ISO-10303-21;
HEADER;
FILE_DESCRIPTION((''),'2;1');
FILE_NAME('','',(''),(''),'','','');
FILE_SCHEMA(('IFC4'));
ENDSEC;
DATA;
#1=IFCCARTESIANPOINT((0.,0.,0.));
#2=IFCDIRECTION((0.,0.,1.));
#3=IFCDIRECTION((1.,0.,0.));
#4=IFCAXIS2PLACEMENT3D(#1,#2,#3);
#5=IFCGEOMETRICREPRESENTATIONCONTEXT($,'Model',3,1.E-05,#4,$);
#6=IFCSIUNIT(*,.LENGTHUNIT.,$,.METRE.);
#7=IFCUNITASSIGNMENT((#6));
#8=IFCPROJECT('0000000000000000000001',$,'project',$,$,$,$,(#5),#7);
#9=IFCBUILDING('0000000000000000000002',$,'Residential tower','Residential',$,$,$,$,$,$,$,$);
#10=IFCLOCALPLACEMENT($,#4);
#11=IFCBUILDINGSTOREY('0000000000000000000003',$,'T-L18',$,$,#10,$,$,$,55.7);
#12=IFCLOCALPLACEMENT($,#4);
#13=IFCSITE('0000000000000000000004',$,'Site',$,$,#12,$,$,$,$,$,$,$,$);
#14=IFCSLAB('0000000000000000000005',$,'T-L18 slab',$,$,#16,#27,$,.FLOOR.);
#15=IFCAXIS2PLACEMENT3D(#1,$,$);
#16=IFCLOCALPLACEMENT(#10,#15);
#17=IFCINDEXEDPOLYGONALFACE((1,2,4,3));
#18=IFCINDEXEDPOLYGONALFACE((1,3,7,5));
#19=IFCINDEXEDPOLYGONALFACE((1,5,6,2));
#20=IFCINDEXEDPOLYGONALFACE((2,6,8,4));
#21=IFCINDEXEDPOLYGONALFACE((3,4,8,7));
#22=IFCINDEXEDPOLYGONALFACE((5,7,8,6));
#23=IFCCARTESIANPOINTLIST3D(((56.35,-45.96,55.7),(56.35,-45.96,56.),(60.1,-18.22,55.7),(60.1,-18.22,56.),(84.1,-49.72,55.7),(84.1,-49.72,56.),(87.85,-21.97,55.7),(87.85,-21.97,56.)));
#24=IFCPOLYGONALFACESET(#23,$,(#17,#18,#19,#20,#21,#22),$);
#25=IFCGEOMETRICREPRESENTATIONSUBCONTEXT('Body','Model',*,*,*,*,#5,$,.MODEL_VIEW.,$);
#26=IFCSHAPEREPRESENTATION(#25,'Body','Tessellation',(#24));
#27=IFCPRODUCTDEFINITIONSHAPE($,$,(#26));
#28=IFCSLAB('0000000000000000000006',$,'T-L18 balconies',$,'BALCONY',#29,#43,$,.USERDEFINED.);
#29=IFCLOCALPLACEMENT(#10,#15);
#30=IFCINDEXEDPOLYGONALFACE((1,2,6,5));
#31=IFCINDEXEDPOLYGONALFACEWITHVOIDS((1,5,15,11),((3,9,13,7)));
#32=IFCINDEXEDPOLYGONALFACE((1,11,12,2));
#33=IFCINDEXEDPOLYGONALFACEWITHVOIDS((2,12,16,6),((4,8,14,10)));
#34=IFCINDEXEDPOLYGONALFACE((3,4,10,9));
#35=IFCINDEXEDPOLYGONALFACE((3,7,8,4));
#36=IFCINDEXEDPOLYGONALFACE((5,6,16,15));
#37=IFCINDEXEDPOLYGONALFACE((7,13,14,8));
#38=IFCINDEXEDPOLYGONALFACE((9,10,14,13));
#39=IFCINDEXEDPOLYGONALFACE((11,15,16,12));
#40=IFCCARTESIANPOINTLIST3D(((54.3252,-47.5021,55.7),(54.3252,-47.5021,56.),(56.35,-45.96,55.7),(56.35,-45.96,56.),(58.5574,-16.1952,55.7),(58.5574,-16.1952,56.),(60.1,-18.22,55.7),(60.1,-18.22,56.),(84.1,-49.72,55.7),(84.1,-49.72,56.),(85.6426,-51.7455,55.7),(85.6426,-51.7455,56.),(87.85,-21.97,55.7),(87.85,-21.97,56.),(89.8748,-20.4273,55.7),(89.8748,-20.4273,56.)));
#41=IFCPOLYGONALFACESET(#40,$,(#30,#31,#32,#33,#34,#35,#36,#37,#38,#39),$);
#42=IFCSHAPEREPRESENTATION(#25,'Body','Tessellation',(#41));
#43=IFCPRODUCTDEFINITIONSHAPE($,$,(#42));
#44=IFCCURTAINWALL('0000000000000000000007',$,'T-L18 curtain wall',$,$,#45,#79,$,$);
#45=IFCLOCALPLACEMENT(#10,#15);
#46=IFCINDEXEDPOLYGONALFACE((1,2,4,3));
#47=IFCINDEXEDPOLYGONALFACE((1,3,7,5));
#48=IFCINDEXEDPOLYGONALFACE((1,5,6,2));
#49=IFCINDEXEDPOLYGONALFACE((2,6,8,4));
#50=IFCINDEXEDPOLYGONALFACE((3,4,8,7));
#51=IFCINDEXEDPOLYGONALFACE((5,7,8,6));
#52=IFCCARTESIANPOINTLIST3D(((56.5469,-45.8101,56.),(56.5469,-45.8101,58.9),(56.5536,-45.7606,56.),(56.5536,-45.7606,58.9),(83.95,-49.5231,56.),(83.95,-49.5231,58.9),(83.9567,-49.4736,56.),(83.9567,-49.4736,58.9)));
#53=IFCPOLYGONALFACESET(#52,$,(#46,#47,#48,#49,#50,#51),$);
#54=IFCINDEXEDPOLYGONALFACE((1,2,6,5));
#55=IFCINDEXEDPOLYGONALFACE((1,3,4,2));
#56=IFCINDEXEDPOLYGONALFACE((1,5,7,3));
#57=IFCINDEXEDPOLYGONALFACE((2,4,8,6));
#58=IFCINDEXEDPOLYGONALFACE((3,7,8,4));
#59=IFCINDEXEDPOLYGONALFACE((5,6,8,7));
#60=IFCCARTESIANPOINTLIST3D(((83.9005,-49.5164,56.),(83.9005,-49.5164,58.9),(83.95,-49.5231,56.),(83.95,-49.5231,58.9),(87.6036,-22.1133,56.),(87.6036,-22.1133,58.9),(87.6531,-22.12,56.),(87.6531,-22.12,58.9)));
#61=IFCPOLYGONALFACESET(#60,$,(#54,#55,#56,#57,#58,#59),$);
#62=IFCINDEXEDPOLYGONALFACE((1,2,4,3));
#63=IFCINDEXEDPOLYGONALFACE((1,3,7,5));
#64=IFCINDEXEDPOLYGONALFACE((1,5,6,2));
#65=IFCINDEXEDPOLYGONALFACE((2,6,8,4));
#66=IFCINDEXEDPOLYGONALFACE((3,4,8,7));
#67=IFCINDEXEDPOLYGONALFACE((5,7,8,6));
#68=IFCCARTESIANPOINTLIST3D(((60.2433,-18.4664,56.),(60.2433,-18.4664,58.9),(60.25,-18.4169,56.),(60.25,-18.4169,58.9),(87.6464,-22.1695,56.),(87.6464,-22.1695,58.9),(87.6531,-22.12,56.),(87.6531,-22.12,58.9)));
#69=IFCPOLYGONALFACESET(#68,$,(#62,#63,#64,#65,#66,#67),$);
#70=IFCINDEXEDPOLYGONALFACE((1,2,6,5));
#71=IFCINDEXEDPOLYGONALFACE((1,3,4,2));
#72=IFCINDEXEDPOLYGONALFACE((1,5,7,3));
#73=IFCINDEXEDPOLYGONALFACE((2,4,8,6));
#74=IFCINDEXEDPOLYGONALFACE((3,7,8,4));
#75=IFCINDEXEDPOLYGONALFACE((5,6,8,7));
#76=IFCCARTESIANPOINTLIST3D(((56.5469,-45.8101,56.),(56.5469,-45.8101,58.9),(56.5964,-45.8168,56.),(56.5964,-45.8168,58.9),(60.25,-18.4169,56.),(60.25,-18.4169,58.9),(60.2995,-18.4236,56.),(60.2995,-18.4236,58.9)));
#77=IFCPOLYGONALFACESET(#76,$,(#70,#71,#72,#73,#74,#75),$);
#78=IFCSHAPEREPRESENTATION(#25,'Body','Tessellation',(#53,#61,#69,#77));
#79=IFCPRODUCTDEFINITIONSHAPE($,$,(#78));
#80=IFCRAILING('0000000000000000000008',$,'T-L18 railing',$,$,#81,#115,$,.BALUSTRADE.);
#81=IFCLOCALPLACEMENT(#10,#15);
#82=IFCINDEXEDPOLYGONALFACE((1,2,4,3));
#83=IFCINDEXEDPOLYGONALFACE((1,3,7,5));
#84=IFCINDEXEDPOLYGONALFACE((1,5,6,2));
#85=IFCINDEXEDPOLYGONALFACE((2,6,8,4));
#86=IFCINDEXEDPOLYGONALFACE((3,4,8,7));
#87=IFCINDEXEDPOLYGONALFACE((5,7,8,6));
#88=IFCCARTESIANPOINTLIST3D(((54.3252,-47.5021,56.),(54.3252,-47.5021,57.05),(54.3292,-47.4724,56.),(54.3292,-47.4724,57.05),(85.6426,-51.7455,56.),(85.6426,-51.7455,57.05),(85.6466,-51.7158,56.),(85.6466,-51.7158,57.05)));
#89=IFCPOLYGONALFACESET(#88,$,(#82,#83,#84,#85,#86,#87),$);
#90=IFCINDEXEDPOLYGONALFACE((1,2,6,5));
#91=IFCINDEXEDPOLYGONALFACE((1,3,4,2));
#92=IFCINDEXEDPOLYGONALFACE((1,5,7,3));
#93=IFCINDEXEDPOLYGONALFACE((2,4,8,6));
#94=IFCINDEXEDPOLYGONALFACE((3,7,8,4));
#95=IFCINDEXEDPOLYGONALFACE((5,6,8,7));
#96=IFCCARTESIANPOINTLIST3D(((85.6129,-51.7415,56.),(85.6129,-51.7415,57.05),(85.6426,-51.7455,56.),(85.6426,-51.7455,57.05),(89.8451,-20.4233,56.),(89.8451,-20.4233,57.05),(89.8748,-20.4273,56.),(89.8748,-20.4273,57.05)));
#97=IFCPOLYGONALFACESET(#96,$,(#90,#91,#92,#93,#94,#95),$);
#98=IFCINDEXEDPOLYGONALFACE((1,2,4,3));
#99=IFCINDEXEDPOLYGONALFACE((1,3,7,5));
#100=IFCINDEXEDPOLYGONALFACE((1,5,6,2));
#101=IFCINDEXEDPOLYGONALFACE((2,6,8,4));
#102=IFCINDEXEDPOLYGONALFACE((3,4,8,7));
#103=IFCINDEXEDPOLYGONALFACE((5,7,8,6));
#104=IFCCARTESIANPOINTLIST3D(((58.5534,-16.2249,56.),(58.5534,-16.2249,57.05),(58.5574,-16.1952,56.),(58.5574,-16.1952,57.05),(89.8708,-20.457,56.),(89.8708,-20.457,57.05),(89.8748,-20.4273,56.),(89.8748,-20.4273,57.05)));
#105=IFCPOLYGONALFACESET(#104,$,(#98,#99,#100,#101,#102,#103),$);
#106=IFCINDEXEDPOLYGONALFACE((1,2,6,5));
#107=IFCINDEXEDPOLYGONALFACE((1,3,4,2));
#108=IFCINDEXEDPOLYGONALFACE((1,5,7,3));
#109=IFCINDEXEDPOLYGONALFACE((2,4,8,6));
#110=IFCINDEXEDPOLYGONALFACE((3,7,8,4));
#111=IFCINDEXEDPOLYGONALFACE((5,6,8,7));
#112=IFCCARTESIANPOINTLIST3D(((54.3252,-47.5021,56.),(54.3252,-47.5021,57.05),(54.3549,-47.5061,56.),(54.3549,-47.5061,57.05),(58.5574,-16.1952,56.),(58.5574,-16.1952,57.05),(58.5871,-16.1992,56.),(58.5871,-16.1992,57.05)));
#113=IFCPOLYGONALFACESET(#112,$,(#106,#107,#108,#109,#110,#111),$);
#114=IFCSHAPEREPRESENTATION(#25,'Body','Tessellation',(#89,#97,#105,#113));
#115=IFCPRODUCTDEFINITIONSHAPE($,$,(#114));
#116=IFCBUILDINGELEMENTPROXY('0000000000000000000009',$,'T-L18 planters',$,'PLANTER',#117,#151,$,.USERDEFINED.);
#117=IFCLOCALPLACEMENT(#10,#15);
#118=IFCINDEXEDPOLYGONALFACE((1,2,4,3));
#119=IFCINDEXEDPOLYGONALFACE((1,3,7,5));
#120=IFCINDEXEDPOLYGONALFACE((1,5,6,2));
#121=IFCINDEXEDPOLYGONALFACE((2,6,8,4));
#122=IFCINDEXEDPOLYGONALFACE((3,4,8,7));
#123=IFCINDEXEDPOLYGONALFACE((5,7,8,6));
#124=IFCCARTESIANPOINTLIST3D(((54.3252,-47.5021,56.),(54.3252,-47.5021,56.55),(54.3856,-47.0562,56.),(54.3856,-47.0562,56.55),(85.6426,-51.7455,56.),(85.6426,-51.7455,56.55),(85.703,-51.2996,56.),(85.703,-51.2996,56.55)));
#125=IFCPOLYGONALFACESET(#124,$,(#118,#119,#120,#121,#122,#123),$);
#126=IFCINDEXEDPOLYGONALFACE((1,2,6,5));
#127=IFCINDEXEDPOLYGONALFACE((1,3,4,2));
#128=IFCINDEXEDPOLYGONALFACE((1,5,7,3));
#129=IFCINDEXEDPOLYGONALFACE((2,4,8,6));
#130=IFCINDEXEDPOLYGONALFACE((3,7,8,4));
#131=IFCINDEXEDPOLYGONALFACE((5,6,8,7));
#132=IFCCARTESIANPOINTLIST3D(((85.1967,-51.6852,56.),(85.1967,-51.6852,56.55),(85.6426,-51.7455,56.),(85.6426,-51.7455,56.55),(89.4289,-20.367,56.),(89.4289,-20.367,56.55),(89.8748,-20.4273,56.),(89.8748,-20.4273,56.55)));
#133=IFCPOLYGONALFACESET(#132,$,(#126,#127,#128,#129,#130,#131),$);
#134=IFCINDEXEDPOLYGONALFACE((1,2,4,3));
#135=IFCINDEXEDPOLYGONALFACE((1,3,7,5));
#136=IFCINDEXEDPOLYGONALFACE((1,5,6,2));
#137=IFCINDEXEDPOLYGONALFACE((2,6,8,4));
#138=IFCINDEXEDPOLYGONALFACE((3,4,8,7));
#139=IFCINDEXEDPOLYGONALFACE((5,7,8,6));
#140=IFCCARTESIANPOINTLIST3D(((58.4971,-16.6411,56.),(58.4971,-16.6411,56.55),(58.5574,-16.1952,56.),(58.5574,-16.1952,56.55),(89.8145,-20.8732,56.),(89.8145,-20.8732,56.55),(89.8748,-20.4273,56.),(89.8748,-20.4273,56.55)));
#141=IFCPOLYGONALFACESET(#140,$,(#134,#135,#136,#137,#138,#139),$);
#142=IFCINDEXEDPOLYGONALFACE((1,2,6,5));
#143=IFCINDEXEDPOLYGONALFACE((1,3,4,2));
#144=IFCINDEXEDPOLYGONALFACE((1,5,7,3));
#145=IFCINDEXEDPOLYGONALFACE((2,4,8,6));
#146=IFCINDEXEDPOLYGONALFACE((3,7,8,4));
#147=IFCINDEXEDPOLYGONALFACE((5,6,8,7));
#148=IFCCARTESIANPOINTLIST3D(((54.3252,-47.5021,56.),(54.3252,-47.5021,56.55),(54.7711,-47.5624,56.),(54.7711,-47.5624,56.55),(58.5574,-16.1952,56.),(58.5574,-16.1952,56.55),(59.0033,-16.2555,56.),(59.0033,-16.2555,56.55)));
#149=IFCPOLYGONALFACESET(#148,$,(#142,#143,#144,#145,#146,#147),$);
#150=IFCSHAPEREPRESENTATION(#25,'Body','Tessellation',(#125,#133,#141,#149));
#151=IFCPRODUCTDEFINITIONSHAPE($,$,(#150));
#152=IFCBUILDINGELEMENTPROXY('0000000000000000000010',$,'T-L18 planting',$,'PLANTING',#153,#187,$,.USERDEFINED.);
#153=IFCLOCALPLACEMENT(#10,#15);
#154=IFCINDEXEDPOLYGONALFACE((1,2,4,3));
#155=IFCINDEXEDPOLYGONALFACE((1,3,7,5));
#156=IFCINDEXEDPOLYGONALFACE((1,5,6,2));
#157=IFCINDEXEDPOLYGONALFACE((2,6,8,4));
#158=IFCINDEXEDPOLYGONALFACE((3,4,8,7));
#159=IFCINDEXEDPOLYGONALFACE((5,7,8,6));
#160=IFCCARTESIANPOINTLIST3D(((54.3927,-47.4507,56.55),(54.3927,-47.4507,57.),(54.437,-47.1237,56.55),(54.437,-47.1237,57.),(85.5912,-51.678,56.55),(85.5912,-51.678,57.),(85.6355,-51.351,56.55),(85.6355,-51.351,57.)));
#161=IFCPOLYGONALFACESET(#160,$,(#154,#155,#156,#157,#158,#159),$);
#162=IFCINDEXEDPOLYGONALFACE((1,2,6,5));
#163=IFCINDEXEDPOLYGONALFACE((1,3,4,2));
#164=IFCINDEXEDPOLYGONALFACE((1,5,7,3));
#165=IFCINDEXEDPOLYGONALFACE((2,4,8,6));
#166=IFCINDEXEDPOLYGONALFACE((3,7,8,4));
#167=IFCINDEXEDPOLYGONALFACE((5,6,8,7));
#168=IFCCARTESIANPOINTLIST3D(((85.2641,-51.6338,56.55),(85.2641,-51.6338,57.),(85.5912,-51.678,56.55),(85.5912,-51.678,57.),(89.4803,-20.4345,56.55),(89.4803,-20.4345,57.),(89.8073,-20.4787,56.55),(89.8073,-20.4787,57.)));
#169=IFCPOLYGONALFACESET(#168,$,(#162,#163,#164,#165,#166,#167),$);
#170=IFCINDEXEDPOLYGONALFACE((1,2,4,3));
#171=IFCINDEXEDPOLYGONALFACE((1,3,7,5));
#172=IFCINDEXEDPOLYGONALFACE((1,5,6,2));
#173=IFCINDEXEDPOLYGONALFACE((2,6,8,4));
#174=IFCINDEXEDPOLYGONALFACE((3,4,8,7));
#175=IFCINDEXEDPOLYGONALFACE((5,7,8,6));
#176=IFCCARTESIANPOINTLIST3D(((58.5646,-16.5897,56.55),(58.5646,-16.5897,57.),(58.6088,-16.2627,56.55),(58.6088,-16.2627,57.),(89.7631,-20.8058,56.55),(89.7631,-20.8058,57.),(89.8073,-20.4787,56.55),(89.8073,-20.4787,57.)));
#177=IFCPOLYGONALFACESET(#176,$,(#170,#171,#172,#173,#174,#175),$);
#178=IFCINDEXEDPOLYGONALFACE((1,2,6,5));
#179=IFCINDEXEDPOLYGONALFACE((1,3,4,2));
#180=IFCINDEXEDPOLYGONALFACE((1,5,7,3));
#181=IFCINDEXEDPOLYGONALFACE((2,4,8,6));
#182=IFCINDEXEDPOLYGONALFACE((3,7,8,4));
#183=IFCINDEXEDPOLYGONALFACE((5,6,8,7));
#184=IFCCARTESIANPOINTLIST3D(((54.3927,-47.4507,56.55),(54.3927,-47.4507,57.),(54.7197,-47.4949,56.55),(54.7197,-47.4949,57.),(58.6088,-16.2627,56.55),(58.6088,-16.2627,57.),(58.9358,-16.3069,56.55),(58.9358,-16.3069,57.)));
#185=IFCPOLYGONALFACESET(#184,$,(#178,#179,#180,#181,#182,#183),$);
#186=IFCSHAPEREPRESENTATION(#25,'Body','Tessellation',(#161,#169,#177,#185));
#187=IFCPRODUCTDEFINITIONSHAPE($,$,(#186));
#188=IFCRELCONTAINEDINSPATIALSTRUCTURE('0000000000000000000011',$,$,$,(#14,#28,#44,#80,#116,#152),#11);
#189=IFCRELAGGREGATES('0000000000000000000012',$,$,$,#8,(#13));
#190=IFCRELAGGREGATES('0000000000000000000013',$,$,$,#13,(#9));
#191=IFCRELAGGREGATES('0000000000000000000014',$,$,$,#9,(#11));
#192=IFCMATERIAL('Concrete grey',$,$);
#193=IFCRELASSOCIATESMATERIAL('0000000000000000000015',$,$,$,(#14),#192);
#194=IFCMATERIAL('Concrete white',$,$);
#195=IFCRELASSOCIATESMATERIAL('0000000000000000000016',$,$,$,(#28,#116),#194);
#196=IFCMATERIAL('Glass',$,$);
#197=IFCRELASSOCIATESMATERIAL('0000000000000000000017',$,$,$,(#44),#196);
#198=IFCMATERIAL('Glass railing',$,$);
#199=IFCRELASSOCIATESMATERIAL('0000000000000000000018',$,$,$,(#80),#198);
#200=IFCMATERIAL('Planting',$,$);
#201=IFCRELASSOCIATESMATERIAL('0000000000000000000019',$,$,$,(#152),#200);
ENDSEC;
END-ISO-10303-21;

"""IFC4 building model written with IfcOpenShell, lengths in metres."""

from ifc_helpers import new_model, si_unit, frame, origin_with_axes, place, context, subcontext, project, spatial, polyline, outline, extrude, material, element, save


model = new_model("IFC4")

# Units and contexts
model_context = context("Model", 3, precision=1e-05, world=origin_with_axes())
body_context = subcontext(model_context, "Body", "Model", "MODEL_VIEW")
ifc_project = project(units=[si_unit("LENGTHUNIT", "METRE")], contexts=[model_context])

# Site, building, storey
site_placement = place(None, origin_with_axes())
site = spatial("IfcSite", under=ifc_project, at=site_placement, Name="Site")
building = spatial("IfcBuilding", under=site, Name="Residential tower", Description="Residential")
storey_placement = place(None, origin_with_axes())
storey = spatial("IfcBuildingStorey", under=building, at=storey_placement, Name="T-L18", Elevation=55.7)

# Slabs
ifc_material_1 = material(Name="Concrete grey")
slab_1_placement = place(storey_placement, origin_with_axes())
element("IfcSlab", 1, at=slab_1_placement, inside=storey, material=ifc_material_1, Name="T-L18 slab", PredefinedType="FLOOR", context=body_context, shape_type="SweptSolid", body=[
    extrude(outline(polyline([(56.35, -45.96), (84.1, -49.72), (87.85, -21.97), (60.1, -18.22), (56.35, -45.96)])), frame((0.0, 0.0, 55.7), z_axis=(0.0, 0.0, 1.0), x_axis=(1.0, 0.0, 0.0)), (0.0, 0.0, 1.0), 0.3),
])
ifc_material_2 = material(Name="Concrete white")
slab_2_placement = place(storey_placement, origin_with_axes())
element("IfcSlab", 2, at=slab_2_placement, inside=storey, material=ifc_material_2, Name="T-L18 balconies", ObjectType="BALCONY", PredefinedType="USERDEFINED", context=body_context, shape_type="SweptSolid", body=[
    extrude(outline(polyline([(54.3252, -47.5021), (85.6426, -51.7455), (89.8748, -20.4273), (58.5574, -16.1952), (54.3252, -47.5021)]), holes=[polyline([(56.35, -45.96), (84.1, -49.72), (87.85, -21.97), (60.1, -18.22), (56.35, -45.96)])]), frame((0.0, 0.0, 55.7), z_axis=(0.0, 0.0, 1.0), x_axis=(1.0, 0.0, 0.0)), (0.0, 0.0, 1.0), 0.3),
])

# Curtain wall
ifc_material_3 = material(Name="Glass")
curtain_wall_placement = place(storey_placement, origin_with_axes())
element("IfcCurtainWall", 3, at=curtain_wall_placement, inside=storey, material=ifc_material_3, Name="T-L18 curtain wall", context=body_context, shape_type="SweptSolid", body=[
    extrude(outline(polyline([(56.5469, -45.8101), (83.95, -49.5231), (83.9567, -49.4736), (56.5536, -45.7606), (56.5469, -45.8101)])), frame((0.0, 0.0, 56.0), z_axis=(0.0, 0.0, 1.0), x_axis=(1.0, 0.0, 0.0)), (0.0, 0.0, 1.0), 2.9),
    extrude(outline(polyline([(83.95, -49.5231), (87.6531, -22.12), (87.6036, -22.1133), (83.9005, -49.5164), (83.95, -49.5231)])), frame((0.0, 0.0, 56.0), z_axis=(0.0, 0.0, 1.0), x_axis=(1.0, 0.0, 0.0)), (0.0, 0.0, 1.0), 2.9),
    extrude(outline(polyline([(87.6531, -22.12), (60.25, -18.4169), (60.2433, -18.4664), (87.6464, -22.1695), (87.6531, -22.12)])), frame((0.0, 0.0, 56.0), z_axis=(0.0, 0.0, 1.0), x_axis=(1.0, 0.0, 0.0)), (0.0, 0.0, 1.0), 2.9),
    extrude(outline(polyline([(60.25, -18.4169), (56.5469, -45.8101), (56.5964, -45.8168), (60.2995, -18.4236), (60.25, -18.4169)])), frame((0.0, 0.0, 56.0), z_axis=(0.0, 0.0, 1.0), x_axis=(1.0, 0.0, 0.0)), (0.0, 0.0, 1.0), 2.9),
])

# Railing
ifc_material_4 = material(Name="Glass railing")
railing_placement = place(storey_placement, origin_with_axes())
element("IfcRailing", 4, at=railing_placement, inside=storey, material=ifc_material_4, Name="T-L18 railing", PredefinedType="BALUSTRADE", context=body_context, shape_type="SweptSolid", body=[
    extrude(outline(polyline([(54.3252, -47.5021), (85.6426, -51.7455), (85.6466, -51.7158), (54.3292, -47.4724), (54.3252, -47.5021)])), frame((0.0, 0.0, 56.0), z_axis=(0.0, 0.0, 1.0), x_axis=(1.0, 0.0, 0.0)), (0.0, 0.0, 1.0), 1.05),
    extrude(outline(polyline([(85.6426, -51.7455), (89.8748, -20.4273), (89.8451, -20.4233), (85.6129, -51.7415), (85.6426, -51.7455)])), frame((0.0, 0.0, 56.0), z_axis=(0.0, 0.0, 1.0), x_axis=(1.0, 0.0, 0.0)), (0.0, 0.0, 1.0), 1.05),
    extrude(outline(polyline([(89.8748, -20.4273), (58.5574, -16.1952), (58.5534, -16.2249), (89.8708, -20.457), (89.8748, -20.4273)])), frame((0.0, 0.0, 56.0), z_axis=(0.0, 0.0, 1.0), x_axis=(1.0, 0.0, 0.0)), (0.0, 0.0, 1.0), 1.05),
    extrude(outline(polyline([(58.5574, -16.1952), (54.3252, -47.5021), (54.3549, -47.5061), (58.5871, -16.1992), (58.5574, -16.1952)])), frame((0.0, 0.0, 56.0), z_axis=(0.0, 0.0, 1.0), x_axis=(1.0, 0.0, 0.0)), (0.0, 0.0, 1.0), 1.05),
])

# Building element proxies
proxy_1_placement = place(storey_placement, origin_with_axes())
element("IfcBuildingElementProxy", 5, at=proxy_1_placement, inside=storey, material=ifc_material_2, Name="T-L18 planters", ObjectType="PLANTER", PredefinedType="USERDEFINED", context=body_context, shape_type="SweptSolid", body=[
    extrude(outline(polyline([(54.3252, -47.5021), (85.6426, -51.7455), (85.703, -51.2996), (54.3856, -47.0562), (54.3252, -47.5021)])), frame((0.0, 0.0, 56.0), z_axis=(0.0, 0.0, 1.0), x_axis=(1.0, 0.0, 0.0)), (0.0, 0.0, 1.0), 0.55),
    extrude(outline(polyline([(85.6426, -51.7455), (89.8748, -20.4273), (89.4289, -20.367), (85.1967, -51.6852), (85.6426, -51.7455)])), frame((0.0, 0.0, 56.0), z_axis=(0.0, 0.0, 1.0), x_axis=(1.0, 0.0, 0.0)), (0.0, 0.0, 1.0), 0.55),
    extrude(outline(polyline([(89.8748, -20.4273), (58.5574, -16.1952), (58.4971, -16.6411), (89.8145, -20.8732), (89.8748, -20.4273)])), frame((0.0, 0.0, 56.0), z_axis=(0.0, 0.0, 1.0), x_axis=(1.0, 0.0, 0.0)), (0.0, 0.0, 1.0), 0.55),
    extrude(outline(polyline([(58.5574, -16.1952), (54.3252, -47.5021), (54.7711, -47.5624), (59.0033, -16.2555), (58.5574, -16.1952)])), frame((0.0, 0.0, 56.0), z_axis=(0.0, 0.0, 1.0), x_axis=(1.0, 0.0, 0.0)), (0.0, 0.0, 1.0), 0.55),
])
ifc_material_5 = material(Name="Planting")
proxy_2_placement = place(storey_placement, origin_with_axes())
element("IfcBuildingElementProxy", 6, at=proxy_2_placement, inside=storey, material=ifc_material_5, Name="T-L18 planting", ObjectType="PLANTING", PredefinedType="USERDEFINED", context=body_context, shape_type="SweptSolid", body=[
    extrude(outline(polyline([(54.3927, -47.4507), (85.5912, -51.678), (85.6355, -51.351), (54.437, -47.1237), (54.3927, -47.4507)])), frame((0.0, 0.0, 56.55), z_axis=(0.0, 0.0, 1.0), x_axis=(1.0, 0.0, 0.0)), (0.0, 0.0, 1.0), 0.45),
    extrude(outline(polyline([(85.5912, -51.678), (89.8073, -20.4787), (89.4803, -20.4345), (85.2641, -51.6338), (85.5912, -51.678)])), frame((0.0, 0.0, 56.55), z_axis=(0.0, 0.0, 1.0), x_axis=(1.0, 0.0, 0.0)), (0.0, 0.0, 1.0), 0.45),
    extrude(outline(polyline([(89.8073, -20.4787), (58.6088, -16.2627), (58.5646, -16.5897), (89.7631, -20.8058), (89.8073, -20.4787)])), frame((0.0, 0.0, 56.55), z_axis=(0.0, 0.0, 1.0), x_axis=(1.0, 0.0, 0.0)), (0.0, 0.0, 1.0), 0.45),
    extrude(outline(polyline([(58.6088, -16.2627), (54.3927, -47.4507), (54.7197, -47.4949), (58.9358, -16.3069), (58.6088, -16.2627)])), frame((0.0, 0.0, 56.55), z_axis=(0.0, 0.0, 1.0), x_axis=(1.0, 0.0, 0.0)), (0.0, 0.0, 1.0), 0.45),
])

save(model, "model.ifc")
